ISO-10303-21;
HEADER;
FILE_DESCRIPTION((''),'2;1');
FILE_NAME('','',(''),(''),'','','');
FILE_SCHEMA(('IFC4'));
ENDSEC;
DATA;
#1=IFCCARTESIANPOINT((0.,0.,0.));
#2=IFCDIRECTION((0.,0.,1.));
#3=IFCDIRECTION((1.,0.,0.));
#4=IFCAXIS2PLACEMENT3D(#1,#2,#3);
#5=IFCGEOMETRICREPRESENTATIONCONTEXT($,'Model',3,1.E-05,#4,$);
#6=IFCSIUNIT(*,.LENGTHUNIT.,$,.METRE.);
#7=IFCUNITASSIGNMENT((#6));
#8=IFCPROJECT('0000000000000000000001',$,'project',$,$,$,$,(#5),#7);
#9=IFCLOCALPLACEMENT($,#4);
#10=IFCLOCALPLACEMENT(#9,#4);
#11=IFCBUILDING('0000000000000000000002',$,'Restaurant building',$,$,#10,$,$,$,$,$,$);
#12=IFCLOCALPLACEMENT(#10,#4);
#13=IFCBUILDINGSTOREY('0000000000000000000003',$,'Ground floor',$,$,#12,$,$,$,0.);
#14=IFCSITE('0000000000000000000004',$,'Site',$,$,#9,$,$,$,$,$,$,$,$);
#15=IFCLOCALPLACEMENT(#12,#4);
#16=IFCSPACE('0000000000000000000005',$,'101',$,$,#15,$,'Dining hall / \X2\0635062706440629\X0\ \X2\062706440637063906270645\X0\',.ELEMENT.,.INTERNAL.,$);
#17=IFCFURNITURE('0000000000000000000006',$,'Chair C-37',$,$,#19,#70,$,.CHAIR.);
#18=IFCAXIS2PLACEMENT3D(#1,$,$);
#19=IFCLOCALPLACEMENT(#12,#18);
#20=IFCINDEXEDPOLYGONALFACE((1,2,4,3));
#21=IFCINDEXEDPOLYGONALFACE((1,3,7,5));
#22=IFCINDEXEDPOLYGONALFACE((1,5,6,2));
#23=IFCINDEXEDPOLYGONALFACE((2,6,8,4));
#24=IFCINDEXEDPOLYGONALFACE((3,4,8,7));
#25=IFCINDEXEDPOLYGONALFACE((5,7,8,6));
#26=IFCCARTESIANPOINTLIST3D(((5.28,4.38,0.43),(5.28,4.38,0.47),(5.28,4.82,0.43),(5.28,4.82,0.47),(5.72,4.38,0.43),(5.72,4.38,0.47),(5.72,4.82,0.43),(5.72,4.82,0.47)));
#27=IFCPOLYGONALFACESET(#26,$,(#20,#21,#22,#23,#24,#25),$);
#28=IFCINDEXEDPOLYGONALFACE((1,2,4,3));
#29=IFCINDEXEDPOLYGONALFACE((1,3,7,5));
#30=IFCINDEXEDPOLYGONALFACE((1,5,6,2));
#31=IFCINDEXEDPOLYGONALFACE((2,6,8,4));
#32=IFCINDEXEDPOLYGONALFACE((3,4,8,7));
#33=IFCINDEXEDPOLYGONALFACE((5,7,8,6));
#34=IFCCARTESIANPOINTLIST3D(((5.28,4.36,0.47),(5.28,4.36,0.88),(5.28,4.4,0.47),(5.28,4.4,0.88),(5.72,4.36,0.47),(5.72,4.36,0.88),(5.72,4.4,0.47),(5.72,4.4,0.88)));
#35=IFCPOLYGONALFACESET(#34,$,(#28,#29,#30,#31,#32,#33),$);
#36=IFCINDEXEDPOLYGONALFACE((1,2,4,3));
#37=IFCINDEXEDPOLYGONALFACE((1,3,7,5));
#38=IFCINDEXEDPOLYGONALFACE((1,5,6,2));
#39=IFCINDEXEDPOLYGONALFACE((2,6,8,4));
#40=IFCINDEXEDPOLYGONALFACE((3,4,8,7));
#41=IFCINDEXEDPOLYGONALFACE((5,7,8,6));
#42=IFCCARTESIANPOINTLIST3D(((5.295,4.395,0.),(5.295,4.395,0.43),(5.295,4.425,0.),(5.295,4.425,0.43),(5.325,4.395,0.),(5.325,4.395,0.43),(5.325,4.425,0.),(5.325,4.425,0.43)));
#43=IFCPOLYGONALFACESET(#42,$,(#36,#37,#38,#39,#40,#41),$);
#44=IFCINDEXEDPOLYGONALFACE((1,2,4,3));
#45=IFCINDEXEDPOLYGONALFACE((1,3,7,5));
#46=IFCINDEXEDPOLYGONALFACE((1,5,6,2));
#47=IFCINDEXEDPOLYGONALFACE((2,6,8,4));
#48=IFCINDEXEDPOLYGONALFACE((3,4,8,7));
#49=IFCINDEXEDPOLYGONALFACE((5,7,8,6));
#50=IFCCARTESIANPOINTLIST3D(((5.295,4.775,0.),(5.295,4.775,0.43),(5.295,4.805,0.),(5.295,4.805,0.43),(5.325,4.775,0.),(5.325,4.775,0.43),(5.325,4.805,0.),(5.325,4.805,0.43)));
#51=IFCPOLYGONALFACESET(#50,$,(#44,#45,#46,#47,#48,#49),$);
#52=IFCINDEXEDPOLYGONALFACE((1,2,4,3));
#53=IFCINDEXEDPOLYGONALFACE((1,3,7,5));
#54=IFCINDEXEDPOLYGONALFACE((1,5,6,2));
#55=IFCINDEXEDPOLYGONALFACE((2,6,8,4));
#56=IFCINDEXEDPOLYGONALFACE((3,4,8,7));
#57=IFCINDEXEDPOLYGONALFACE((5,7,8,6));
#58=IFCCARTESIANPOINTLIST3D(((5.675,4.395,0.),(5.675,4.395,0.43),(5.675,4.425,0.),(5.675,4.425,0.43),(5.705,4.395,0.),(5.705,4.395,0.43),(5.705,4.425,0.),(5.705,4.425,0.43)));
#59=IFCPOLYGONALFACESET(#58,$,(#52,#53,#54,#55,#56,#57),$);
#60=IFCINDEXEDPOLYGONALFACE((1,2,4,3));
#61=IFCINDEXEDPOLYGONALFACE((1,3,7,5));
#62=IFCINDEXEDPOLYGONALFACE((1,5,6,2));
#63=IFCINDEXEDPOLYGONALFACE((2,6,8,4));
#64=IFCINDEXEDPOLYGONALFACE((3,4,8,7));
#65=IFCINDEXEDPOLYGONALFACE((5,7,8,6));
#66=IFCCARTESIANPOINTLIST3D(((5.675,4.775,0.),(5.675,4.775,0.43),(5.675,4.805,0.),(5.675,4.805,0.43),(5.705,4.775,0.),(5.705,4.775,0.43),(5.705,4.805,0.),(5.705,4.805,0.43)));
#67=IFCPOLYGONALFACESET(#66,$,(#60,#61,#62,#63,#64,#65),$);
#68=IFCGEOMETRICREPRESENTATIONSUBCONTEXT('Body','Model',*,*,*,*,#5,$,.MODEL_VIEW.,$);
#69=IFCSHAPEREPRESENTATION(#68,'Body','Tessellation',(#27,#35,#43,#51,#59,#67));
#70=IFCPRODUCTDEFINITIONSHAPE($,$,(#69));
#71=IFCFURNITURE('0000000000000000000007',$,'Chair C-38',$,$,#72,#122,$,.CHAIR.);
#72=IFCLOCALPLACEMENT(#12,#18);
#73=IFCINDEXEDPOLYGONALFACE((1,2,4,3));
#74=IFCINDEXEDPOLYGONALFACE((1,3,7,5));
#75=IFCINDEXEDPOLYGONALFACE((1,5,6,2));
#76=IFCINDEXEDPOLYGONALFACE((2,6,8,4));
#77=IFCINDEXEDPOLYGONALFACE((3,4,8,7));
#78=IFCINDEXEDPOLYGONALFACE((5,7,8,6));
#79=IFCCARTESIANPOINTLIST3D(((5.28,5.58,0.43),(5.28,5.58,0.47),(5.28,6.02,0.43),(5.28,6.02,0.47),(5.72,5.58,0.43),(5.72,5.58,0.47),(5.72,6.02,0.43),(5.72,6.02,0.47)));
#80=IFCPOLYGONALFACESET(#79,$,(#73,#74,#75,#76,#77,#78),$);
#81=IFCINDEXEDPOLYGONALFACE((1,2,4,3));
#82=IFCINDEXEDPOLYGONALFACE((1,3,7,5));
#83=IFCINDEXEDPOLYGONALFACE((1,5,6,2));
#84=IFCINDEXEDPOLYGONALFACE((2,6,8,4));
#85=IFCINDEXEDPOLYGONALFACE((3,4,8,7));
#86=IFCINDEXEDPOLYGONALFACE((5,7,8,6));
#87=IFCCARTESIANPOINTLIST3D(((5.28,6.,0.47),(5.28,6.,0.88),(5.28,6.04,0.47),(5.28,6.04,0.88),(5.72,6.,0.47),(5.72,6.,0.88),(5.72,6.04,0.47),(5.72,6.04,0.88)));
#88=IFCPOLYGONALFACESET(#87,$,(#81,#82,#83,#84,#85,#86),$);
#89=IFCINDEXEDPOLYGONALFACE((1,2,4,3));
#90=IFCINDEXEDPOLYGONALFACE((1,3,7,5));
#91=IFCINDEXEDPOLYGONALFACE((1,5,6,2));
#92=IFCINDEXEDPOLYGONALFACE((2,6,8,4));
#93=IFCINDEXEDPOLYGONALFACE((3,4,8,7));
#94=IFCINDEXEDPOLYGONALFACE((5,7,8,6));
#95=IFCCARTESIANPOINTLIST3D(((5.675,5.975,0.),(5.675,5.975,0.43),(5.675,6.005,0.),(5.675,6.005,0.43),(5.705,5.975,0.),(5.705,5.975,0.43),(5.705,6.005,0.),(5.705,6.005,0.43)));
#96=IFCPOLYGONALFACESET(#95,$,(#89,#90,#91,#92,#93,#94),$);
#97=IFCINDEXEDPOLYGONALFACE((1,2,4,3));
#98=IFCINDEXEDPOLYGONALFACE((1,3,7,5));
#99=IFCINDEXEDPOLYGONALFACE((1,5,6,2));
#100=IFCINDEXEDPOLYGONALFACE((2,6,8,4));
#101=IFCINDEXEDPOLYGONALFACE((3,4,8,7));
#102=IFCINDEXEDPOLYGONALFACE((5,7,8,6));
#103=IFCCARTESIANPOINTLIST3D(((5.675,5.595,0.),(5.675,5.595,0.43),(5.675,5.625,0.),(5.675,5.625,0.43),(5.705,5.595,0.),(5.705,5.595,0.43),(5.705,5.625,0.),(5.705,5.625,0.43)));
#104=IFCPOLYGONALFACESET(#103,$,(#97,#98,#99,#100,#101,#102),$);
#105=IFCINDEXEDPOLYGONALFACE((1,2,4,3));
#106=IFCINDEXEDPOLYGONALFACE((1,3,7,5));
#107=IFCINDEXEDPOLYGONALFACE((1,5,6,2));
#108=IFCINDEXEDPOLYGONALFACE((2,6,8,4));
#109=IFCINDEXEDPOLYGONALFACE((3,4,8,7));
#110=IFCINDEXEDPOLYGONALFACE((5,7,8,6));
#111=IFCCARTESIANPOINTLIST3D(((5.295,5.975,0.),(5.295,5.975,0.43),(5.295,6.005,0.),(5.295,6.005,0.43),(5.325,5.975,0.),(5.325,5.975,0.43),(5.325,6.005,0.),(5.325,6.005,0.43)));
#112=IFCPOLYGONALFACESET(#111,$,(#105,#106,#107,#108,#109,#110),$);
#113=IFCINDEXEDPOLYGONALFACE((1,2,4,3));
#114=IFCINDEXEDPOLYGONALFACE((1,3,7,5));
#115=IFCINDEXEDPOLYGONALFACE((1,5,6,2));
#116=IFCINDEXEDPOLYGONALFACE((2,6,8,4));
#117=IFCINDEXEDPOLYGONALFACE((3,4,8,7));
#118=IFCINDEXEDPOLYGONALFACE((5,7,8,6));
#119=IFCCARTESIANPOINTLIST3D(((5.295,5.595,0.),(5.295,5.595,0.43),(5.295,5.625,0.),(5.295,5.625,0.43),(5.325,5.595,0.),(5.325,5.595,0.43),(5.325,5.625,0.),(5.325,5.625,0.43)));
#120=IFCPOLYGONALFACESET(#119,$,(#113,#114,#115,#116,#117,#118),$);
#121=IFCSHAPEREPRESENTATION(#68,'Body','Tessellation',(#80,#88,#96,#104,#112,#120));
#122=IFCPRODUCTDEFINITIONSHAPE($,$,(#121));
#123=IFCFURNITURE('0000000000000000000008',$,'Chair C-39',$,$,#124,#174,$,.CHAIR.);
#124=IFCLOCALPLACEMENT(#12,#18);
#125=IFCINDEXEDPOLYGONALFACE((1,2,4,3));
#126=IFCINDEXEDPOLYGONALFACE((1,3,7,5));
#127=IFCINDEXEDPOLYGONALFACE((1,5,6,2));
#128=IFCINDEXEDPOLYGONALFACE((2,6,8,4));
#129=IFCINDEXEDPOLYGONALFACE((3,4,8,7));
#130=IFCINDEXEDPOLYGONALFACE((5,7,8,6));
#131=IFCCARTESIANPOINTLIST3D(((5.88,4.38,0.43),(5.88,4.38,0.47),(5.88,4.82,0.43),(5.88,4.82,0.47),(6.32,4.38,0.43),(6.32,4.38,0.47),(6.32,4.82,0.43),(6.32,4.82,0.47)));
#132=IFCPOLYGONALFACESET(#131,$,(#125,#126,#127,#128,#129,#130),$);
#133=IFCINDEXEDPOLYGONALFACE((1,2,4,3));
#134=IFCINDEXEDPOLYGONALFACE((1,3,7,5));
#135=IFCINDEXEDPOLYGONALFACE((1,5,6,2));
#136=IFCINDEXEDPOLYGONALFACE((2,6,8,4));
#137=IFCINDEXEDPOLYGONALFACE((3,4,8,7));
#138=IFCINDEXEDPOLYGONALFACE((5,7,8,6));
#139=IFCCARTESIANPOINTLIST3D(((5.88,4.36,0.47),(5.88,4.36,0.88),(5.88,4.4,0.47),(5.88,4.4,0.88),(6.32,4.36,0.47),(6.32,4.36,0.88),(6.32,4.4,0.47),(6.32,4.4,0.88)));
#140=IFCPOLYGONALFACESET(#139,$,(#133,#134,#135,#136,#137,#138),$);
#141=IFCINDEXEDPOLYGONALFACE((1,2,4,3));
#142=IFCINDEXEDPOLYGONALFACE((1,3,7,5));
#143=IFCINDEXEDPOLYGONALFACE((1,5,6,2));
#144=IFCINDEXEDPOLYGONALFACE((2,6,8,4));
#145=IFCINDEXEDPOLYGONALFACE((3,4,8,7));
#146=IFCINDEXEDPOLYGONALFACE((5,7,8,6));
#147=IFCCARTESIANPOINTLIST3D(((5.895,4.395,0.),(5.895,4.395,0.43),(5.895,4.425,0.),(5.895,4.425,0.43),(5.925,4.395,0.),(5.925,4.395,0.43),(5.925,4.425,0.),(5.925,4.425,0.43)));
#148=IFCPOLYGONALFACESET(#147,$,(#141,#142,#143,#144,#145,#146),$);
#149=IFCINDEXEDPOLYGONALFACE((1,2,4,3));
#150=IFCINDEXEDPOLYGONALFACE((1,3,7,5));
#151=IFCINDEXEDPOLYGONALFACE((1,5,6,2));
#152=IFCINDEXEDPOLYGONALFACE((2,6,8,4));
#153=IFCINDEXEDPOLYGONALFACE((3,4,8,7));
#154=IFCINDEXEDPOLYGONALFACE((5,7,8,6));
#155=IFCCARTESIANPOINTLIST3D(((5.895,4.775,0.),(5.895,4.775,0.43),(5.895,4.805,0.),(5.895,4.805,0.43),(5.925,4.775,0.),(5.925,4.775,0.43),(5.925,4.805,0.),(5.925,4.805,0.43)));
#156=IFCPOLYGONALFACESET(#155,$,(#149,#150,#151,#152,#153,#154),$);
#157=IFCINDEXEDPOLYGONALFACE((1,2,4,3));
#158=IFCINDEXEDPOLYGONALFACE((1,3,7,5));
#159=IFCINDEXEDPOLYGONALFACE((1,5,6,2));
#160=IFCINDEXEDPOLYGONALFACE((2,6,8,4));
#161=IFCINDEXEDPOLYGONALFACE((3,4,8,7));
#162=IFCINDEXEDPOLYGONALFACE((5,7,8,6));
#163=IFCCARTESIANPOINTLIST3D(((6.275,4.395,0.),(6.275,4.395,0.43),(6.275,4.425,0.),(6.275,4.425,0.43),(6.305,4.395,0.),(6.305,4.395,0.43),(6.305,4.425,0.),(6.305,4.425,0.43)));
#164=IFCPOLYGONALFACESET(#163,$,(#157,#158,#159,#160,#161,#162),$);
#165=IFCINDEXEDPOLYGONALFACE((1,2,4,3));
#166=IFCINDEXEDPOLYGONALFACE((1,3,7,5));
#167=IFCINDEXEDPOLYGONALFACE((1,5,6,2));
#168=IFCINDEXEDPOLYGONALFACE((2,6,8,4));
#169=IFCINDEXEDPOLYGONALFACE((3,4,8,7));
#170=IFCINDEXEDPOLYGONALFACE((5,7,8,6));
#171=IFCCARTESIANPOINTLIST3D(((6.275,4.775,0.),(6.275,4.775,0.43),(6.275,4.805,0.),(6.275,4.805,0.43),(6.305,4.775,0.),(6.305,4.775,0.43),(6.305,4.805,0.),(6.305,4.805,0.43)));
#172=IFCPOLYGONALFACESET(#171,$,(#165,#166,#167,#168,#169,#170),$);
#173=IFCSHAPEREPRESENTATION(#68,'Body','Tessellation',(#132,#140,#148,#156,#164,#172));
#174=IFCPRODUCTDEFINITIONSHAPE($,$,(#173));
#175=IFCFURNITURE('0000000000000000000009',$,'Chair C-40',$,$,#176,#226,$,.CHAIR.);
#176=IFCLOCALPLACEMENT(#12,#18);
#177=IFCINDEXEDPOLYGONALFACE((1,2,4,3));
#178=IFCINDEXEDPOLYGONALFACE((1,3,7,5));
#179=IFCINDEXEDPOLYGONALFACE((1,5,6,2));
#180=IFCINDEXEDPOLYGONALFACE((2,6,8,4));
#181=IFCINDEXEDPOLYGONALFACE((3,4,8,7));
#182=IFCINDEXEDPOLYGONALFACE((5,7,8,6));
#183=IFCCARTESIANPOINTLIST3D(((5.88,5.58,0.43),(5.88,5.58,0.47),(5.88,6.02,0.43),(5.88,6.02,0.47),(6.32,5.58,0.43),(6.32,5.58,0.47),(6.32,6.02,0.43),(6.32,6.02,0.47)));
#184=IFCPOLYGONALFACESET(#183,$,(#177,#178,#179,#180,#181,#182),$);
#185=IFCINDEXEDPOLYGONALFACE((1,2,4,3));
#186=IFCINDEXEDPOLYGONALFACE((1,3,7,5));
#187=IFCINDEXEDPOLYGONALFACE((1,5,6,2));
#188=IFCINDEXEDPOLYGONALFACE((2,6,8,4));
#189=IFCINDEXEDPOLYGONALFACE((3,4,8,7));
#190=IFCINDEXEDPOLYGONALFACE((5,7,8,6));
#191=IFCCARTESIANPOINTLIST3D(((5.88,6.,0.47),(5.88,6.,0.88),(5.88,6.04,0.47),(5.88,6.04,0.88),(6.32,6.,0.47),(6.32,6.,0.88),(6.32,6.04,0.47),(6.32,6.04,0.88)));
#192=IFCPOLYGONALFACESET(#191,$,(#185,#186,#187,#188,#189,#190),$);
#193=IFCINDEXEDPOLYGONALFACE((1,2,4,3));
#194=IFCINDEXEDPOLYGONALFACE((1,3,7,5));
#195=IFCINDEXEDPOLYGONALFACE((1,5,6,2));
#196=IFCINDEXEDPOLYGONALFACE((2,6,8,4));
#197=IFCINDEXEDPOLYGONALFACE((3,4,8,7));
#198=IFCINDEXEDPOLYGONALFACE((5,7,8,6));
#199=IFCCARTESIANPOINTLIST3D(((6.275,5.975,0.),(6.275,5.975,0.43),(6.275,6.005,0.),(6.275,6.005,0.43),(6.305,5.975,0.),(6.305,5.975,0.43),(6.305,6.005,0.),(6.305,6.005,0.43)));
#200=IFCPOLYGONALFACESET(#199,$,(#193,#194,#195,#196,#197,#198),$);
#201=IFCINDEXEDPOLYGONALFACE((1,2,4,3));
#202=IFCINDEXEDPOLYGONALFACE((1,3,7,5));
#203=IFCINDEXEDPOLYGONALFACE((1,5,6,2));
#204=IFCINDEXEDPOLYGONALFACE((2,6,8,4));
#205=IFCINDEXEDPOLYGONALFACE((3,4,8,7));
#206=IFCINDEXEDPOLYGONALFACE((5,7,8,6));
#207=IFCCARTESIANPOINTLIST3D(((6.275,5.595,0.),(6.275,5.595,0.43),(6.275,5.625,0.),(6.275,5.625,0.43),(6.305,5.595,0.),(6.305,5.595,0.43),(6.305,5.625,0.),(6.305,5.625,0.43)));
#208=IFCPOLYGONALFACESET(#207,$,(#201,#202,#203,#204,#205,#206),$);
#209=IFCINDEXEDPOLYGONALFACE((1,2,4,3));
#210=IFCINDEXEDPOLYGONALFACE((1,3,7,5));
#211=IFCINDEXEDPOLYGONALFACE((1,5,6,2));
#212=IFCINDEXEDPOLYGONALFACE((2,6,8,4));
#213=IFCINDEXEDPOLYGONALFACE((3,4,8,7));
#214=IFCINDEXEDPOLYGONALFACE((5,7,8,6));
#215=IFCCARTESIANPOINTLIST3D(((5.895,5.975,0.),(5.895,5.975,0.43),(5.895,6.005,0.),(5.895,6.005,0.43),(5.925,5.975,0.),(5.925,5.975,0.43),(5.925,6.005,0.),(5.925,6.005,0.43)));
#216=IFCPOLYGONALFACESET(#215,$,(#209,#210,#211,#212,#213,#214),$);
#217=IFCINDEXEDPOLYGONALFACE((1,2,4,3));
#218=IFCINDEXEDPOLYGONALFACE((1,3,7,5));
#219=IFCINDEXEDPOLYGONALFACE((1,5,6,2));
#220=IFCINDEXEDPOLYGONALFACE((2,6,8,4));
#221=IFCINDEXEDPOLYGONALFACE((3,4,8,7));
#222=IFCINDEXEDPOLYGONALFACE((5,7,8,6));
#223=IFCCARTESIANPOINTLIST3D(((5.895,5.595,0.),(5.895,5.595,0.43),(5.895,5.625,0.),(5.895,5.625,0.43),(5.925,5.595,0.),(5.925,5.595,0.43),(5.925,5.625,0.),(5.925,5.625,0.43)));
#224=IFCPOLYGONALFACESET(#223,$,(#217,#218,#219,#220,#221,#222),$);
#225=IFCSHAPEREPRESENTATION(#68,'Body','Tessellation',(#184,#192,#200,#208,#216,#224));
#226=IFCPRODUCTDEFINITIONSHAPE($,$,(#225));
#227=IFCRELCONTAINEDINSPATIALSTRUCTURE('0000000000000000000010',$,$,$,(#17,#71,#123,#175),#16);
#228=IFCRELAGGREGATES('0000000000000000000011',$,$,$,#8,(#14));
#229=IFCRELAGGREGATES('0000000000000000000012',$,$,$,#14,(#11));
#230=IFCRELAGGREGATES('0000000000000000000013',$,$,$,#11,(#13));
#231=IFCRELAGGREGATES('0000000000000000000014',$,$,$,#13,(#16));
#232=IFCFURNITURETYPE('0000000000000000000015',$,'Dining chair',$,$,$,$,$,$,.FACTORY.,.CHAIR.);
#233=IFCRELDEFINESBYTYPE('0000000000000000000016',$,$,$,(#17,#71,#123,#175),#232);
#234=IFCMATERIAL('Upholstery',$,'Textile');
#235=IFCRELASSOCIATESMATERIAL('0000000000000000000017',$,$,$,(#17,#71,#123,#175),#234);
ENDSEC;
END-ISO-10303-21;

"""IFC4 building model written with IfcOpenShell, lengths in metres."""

from ifc_helpers import new_model, si_unit, frame, origin, origin_with_axes, origin_2d, place, context, subcontext, project, spatial, rectangle, extrude, source, transform, mapped, material, type_object, type_shapes, element, save


model = new_model("IFC4")

# Units and contexts
model_context = context("Model", 3, precision=1e-05, world=origin_with_axes())
body_context = subcontext(model_context, "Body", "Model", "MODEL_VIEW")
ifc_project = project(units=[si_unit("LENGTHUNIT", "METRE")], contexts=[model_context])

# Site, building, storey, space
site_placement = place(None, origin_with_axes())
site = spatial("IfcSite", under=ifc_project, at=site_placement, Name="Site")
building_placement = place(site_placement, origin_with_axes())
building = spatial("IfcBuilding", under=site, at=building_placement, Name="Restaurant building")
storey_placement = place(building_placement, origin_with_axes())
storey = spatial("IfcBuildingStorey", under=building, at=storey_placement, Name="Ground floor", Elevation=0.0)
space_placement = place(storey_placement, origin_with_axes())
space = spatial("IfcSpace", under=storey, at=space_placement, Name="101", LongName="Dining hall / صالة الطعام", CompositionType="ELEMENT", PredefinedType="INTERNAL")

# Furniture
ifc_material_1 = material(Name="Upholstery", Category="Textile")
furniture_type_1 = type_object("IfcFurnitureType", Name="Dining chair", AssemblyPlace="FACTORY", PredefinedType="CHAIR")
shared_shape_1 = source(origin(), body_context, "Body", "SweptSolid", [
    extrude(rectangle(XDim=0.44, YDim=0.44, at=origin_2d()), frame((0.0, 0.0, 0.43)), (0.0, 0.0, 1.0), 0.04),
    extrude(rectangle(XDim=0.44, YDim=0.04, at=origin_2d()), frame((0.0, -0.22, 0.47)), (0.0, 0.0, 1.0), 0.41),
    extrude(rectangle(XDim=0.03, YDim=0.03, at=origin_2d()), frame((-0.19, -0.19, 0.0)), (0.0, 0.0, 1.0), 0.43),
    extrude(rectangle(XDim=0.03, YDim=0.03, at=origin_2d()), frame((-0.19, 0.19, 0.0)), (0.0, 0.0, 1.0), 0.43),
    extrude(rectangle(XDim=0.03, YDim=0.03, at=origin_2d()), frame((0.19, -0.19, 0.0)), (0.0, 0.0, 1.0), 0.43),
    extrude(rectangle(XDim=0.03, YDim=0.03, at=origin_2d()), frame((0.19, 0.19, 0.0)), (0.0, 0.0, 1.0), 0.43),
])
type_shapes(furniture_type_1, [shared_shape_1])
furniture_1_placement = place(storey_placement, frame((5.5, 4.6, 0.0)))
element("IfcFurniture", 1, at=furniture_1_placement, inside=space, type_object=furniture_type_1, material=ifc_material_1, Name="Chair C-37", PredefinedType="CHAIR", context=body_context, shape_type="MappedRepresentation", body=[
    mapped(shared_shape_1, transform((0.0, 0.0, 0.0))),
])
furniture_2_placement = place(storey_placement, frame((5.5, 5.8, 0.0), z_axis=(0.0, 0.0, 1.0), x_axis=(-1.0, 0.0, 0.0)))
element("IfcFurniture", 2, at=furniture_2_placement, inside=space, type_object=furniture_type_1, material=ifc_material_1, Name="Chair C-38", PredefinedType="CHAIR", context=body_context, shape_type="MappedRepresentation", body=[
    mapped(shared_shape_1, transform((0.0, 0.0, 0.0))),
])
furniture_3_placement = place(storey_placement, frame((6.1, 4.6, 0.0)))
element("IfcFurniture", 3, at=furniture_3_placement, inside=space, type_object=furniture_type_1, material=ifc_material_1, Name="Chair C-39", PredefinedType="CHAIR", context=body_context, shape_type="MappedRepresentation", body=[
    mapped(shared_shape_1, transform((0.0, 0.0, 0.0))),
])
furniture_4_placement = place(storey_placement, frame((6.1, 5.8, 0.0), z_axis=(0.0, 0.0, 1.0), x_axis=(-1.0, 0.0, 0.0)))
element("IfcFurniture", 4, at=furniture_4_placement, inside=space, type_object=furniture_type_1, material=ifc_material_1, Name="Chair C-40", PredefinedType="CHAIR", context=body_context, shape_type="MappedRepresentation", body=[
    mapped(shared_shape_1, transform((0.0, 0.0, 0.0))),
])

save(model, "model.ifc")
